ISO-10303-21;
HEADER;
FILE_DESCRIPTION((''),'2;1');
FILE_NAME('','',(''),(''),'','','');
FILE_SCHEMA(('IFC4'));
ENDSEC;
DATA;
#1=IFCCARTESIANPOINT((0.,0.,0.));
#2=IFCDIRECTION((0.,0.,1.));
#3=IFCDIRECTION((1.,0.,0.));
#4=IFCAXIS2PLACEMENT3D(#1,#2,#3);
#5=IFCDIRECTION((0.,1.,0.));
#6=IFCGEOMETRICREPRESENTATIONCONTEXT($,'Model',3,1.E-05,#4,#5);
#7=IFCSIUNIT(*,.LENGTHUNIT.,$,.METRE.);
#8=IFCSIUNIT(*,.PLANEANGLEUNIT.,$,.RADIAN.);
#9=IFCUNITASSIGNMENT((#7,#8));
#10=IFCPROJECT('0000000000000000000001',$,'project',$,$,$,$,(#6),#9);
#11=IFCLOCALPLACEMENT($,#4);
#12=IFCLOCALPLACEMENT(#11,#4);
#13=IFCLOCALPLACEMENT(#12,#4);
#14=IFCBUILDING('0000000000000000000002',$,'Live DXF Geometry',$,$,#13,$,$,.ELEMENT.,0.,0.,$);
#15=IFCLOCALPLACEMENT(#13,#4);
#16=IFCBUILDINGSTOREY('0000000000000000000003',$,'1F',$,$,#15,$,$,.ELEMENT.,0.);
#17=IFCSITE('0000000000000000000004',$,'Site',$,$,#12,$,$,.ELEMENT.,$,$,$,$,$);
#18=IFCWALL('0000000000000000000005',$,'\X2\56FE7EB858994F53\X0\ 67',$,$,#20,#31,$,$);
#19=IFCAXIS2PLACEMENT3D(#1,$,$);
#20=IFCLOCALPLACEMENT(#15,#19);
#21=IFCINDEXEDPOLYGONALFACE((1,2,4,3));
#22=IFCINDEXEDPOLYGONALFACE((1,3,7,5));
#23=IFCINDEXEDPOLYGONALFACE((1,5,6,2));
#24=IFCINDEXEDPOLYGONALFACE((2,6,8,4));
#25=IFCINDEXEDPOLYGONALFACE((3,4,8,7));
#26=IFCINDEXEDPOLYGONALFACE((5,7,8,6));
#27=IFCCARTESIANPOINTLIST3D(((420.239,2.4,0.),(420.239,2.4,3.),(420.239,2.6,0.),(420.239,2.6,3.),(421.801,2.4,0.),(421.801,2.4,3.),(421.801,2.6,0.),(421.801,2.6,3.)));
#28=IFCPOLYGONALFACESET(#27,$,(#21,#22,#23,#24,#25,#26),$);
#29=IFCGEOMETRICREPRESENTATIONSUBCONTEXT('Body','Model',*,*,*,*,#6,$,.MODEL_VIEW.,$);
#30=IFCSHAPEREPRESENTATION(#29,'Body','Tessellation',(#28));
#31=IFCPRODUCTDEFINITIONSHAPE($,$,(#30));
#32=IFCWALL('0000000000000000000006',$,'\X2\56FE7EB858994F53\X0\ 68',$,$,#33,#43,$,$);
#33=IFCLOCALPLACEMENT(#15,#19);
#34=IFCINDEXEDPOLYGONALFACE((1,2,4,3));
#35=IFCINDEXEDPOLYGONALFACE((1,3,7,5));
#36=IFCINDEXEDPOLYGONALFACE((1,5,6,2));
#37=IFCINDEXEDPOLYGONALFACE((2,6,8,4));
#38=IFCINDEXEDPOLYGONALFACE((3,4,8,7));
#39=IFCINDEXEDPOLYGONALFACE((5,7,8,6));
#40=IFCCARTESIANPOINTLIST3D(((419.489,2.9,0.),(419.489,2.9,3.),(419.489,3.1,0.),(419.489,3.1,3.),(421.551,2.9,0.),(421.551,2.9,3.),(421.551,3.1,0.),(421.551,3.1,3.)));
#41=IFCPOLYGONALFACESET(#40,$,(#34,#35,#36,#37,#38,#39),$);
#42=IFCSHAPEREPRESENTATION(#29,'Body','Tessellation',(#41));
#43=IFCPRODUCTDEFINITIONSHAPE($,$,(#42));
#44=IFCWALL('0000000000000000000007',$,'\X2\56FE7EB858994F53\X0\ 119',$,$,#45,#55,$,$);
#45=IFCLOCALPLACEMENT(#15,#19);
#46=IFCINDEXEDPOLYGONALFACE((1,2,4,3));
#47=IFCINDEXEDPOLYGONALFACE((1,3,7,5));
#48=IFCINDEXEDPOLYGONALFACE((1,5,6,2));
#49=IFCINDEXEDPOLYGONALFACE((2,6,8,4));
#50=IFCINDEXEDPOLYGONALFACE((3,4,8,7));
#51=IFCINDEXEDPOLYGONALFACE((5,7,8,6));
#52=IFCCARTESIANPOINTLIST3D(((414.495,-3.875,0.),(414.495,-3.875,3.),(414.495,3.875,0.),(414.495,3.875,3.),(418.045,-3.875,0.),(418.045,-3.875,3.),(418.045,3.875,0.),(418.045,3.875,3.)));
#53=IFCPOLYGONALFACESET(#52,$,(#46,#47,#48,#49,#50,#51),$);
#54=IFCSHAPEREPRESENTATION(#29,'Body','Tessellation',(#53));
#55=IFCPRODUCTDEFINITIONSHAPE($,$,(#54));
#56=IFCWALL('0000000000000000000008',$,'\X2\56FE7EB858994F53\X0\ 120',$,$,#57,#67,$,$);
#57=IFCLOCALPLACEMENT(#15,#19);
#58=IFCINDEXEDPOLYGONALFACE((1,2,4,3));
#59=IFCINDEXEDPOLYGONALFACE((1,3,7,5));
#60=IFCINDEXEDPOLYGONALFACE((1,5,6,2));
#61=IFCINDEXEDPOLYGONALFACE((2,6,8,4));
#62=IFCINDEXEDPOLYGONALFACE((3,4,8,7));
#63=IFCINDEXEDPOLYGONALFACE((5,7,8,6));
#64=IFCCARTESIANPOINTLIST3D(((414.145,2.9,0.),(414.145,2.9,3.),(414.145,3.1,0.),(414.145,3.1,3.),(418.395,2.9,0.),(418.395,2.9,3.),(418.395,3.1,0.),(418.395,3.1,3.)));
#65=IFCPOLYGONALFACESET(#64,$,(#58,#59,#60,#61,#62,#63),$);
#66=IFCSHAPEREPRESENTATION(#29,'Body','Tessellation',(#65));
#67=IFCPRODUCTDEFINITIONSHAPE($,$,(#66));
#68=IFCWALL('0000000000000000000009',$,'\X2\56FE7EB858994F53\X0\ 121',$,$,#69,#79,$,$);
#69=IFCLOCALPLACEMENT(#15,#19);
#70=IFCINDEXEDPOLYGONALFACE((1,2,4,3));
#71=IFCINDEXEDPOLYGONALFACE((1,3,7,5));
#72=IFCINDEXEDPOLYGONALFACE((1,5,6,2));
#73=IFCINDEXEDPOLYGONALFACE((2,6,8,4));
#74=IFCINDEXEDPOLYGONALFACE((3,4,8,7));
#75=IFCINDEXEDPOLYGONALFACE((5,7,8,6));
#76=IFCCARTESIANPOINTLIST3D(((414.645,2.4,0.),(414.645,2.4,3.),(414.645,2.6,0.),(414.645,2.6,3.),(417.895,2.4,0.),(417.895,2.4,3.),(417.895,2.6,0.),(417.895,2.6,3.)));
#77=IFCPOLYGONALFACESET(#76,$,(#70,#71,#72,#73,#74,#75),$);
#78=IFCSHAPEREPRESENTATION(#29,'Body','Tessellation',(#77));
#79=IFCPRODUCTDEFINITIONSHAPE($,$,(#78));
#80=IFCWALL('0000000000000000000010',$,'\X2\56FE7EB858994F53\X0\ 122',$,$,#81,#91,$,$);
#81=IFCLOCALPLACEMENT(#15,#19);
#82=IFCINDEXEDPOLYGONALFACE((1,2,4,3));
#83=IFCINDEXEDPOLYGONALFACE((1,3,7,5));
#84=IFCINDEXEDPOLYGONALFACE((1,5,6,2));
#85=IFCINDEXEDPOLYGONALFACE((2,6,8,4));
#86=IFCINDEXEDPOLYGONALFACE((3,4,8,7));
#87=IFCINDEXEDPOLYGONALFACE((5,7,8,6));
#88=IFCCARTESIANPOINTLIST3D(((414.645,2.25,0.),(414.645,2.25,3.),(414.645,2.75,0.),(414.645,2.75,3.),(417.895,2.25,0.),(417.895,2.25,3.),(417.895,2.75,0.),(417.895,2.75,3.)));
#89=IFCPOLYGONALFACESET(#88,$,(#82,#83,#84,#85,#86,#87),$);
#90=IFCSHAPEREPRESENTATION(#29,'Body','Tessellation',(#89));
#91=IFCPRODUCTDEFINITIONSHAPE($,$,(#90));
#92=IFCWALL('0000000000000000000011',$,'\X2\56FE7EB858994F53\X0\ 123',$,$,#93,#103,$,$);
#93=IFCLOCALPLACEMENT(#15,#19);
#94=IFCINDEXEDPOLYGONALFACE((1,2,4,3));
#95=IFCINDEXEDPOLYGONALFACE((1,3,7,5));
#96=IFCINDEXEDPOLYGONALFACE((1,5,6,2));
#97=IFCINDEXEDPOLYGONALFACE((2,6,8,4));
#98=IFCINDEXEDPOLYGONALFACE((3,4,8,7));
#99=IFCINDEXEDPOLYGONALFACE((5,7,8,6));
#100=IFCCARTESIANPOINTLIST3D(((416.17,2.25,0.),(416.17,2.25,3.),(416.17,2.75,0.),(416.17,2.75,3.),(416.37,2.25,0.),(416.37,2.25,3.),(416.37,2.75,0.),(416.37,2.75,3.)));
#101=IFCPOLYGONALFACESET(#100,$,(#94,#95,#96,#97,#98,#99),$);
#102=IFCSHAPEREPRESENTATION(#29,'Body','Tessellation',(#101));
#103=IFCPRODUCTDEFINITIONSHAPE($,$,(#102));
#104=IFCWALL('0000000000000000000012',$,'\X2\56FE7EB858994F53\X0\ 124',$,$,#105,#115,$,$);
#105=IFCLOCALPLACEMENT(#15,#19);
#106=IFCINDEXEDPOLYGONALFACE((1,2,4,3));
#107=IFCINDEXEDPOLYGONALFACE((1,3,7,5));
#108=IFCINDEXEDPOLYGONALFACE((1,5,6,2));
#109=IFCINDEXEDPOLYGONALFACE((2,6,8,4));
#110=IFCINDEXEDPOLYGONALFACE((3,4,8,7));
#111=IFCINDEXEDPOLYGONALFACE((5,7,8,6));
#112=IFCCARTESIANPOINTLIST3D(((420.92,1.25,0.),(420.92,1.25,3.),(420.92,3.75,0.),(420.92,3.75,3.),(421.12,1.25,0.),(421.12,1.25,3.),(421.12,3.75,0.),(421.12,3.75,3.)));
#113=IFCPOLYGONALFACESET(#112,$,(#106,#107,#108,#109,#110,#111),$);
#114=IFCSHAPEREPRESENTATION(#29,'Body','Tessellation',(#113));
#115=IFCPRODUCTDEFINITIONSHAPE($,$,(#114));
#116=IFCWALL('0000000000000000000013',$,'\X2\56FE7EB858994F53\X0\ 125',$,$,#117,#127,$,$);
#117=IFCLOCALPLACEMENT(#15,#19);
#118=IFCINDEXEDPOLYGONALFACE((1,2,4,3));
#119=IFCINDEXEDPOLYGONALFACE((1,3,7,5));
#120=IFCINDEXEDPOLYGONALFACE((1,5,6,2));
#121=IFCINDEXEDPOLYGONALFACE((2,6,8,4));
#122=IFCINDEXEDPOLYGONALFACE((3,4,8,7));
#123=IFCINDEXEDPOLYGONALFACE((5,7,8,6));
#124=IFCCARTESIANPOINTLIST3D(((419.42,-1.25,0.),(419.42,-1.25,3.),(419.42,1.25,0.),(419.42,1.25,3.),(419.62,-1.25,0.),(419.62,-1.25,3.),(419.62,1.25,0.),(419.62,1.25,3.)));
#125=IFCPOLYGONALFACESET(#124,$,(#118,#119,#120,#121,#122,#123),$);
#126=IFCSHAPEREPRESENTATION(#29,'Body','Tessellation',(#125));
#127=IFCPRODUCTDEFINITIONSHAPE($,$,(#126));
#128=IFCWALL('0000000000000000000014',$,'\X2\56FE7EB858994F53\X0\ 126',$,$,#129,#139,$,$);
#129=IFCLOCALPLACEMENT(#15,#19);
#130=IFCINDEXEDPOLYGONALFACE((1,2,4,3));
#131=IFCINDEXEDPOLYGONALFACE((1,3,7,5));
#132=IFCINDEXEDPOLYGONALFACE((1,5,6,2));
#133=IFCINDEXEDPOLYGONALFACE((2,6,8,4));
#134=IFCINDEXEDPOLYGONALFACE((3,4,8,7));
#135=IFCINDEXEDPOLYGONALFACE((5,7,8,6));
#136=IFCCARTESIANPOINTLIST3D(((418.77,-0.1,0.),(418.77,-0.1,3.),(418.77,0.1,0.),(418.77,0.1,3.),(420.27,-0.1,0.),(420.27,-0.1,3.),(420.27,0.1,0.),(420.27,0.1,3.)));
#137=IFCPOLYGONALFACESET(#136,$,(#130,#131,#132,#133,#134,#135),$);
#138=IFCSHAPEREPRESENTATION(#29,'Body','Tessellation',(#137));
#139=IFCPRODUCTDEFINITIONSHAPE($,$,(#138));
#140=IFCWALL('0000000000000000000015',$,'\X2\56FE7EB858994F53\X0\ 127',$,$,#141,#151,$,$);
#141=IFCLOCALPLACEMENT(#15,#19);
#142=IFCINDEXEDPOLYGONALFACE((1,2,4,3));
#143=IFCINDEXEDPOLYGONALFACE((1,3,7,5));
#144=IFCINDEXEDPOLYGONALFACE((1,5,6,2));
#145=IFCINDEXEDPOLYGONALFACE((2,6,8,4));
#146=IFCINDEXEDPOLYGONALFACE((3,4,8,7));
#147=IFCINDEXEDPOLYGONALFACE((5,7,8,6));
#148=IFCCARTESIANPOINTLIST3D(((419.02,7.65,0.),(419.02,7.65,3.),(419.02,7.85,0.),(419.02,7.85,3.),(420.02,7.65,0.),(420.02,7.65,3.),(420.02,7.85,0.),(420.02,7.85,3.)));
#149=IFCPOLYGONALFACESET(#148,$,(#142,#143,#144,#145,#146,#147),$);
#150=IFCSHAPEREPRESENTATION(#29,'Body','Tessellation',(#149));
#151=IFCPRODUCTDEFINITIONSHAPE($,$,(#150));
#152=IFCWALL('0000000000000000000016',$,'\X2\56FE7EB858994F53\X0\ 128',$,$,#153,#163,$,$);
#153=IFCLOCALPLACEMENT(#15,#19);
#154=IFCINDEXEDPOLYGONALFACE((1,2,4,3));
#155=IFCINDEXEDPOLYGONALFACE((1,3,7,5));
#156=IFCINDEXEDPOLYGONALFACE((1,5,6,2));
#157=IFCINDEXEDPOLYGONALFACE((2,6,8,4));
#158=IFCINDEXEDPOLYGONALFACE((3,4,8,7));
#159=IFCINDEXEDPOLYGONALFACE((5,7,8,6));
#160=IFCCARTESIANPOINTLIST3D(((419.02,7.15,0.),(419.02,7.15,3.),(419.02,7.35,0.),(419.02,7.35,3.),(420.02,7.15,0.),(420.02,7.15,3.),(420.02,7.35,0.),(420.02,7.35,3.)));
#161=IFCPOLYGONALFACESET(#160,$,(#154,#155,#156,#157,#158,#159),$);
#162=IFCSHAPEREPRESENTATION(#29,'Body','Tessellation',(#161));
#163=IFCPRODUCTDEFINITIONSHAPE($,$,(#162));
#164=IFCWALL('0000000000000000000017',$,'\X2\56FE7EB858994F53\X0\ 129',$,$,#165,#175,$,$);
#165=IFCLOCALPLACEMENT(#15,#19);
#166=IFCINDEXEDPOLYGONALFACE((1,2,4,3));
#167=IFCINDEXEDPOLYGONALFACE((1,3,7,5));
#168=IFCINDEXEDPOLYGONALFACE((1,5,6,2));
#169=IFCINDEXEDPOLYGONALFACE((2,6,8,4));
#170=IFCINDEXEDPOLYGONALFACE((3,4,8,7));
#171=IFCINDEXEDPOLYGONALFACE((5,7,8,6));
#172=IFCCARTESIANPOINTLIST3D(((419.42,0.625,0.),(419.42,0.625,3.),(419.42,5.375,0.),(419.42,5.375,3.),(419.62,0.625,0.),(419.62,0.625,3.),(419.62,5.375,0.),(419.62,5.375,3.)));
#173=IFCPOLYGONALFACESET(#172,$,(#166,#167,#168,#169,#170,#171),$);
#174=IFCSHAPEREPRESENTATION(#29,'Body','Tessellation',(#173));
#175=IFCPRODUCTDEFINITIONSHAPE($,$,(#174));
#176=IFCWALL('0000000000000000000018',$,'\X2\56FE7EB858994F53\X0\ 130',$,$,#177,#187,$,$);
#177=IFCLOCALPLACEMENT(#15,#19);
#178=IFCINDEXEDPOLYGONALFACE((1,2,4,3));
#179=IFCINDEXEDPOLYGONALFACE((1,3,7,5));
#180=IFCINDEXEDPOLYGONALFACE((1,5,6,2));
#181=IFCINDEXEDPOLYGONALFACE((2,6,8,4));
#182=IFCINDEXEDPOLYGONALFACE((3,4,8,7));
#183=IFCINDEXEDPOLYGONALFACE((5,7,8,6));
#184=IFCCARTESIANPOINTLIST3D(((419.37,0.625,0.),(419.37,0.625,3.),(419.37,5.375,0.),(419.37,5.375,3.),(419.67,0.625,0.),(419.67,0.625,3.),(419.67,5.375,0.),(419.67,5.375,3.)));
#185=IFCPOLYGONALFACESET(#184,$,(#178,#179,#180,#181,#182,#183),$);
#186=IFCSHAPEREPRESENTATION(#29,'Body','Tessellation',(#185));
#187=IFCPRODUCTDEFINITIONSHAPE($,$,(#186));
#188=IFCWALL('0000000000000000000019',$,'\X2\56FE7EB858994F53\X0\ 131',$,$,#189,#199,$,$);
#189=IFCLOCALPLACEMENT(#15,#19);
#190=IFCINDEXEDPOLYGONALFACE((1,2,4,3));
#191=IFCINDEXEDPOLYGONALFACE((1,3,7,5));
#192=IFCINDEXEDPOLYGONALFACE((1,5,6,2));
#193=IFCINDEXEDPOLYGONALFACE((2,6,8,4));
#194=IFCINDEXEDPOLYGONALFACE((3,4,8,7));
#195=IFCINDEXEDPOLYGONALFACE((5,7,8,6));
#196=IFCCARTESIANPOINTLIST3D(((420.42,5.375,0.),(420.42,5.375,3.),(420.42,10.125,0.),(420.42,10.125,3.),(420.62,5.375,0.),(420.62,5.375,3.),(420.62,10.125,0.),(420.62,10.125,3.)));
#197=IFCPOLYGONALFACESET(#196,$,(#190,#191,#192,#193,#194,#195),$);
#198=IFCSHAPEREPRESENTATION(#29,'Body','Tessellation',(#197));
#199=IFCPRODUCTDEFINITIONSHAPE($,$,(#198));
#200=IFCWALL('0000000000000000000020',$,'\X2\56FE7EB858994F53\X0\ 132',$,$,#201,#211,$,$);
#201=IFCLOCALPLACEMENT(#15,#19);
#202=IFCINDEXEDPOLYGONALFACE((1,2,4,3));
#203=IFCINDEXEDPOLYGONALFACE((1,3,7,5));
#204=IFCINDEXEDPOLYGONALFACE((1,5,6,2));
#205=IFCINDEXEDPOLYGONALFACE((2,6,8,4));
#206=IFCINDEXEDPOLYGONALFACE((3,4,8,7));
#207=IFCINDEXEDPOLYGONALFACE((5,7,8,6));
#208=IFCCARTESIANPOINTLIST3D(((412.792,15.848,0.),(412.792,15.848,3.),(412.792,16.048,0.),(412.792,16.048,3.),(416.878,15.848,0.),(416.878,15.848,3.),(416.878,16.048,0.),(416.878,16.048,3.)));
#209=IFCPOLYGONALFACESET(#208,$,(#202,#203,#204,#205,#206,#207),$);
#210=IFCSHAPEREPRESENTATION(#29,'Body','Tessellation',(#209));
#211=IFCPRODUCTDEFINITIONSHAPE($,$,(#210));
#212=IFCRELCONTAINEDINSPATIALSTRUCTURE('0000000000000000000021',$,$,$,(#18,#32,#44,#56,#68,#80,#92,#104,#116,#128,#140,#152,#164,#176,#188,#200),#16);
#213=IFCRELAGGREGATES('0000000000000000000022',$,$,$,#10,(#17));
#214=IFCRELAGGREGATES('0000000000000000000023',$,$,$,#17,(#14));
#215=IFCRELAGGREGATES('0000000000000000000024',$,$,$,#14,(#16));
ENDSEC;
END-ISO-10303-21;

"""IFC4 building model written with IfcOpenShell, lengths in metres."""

from ifc_helpers import new_model, si_unit, direction, frame, frame_2d, origin_with_axes, place, context, subcontext, project, spatial, rectangle, extrude, element, save


model = new_model("IFC4")

# Units and contexts
model_context = context("Model", 3, precision=1e-05, world=origin_with_axes(), true_north=direction((0.0, 1.0, 0.0)))
body_context = subcontext(model_context, "Body", "Model", "MODEL_VIEW")
ifc_project = project(units=[si_unit("LENGTHUNIT", "METRE"), si_unit("PLANEANGLEUNIT", "RADIAN")], contexts=[model_context])

# Site, building, storey
placement = place(None, origin_with_axes())
site_placement = place(placement, origin_with_axes())
site = spatial("IfcSite", under=ifc_project, at=site_placement, Name="Site", CompositionType="ELEMENT")
building_placement = place(site_placement, origin_with_axes())
building = spatial("IfcBuilding", under=site, at=building_placement, Name="Live DXF Geometry", CompositionType="ELEMENT", ElevationOfRefHeight=0.0, ElevationOfTerrain=0.0)
storey_placement = place(building_placement, origin_with_axes())
storey = spatial("IfcBuildingStorey", under=building, at=storey_placement, Name="1F", CompositionType="ELEMENT", Elevation=0.0)

# Walls
wall_1_placement = place(storey_placement, frame((421.02, 2.5, 0.0), z_axis=(0.0, 0.0, 1.0), x_axis=(1.0, 0.0, 0.0)))
element("IfcWall", 1, at=wall_1_placement, inside=storey, Name="图纸墙体 67", context=body_context, shape_type="SweptSolid", body=[
    extrude(rectangle(XDim=1.562, YDim=0.2, at=frame_2d((0.0, 0.0), x_axis=(1.0, 0.0, 0.0))), frame((0.0, 0.0, 0.0), z_axis=(0.0, 0.0, 1.0)), (0.0, 0.0, 1.0), 3.0),
])
wall_2_placement = place(storey_placement, frame((420.52, 3.0, 0.0), z_axis=(0.0, 0.0, 1.0), x_axis=(1.0, 0.0, 0.0)))
element("IfcWall", 2, at=wall_2_placement, inside=storey, Name="图纸墙体 68", context=body_context, shape_type="SweptSolid", body=[
    extrude(rectangle(XDim=2.062, YDim=0.2, at=frame_2d((0.0, 0.0), x_axis=(1.0, 0.0, 0.0))), frame((0.0, 0.0, 0.0), z_axis=(0.0, 0.0, 1.0)), (0.0, 0.0, 1.0), 3.0),
])
wall_3_placement = place(storey_placement, frame((416.27, 0.0, 0.0), z_axis=(0.0, 0.0, 1.0), x_axis=(1.0, 0.0, 0.0)))
element("IfcWall", 3, at=wall_3_placement, inside=storey, Name="图纸墙体 119", context=body_context, shape_type="SweptSolid", body=[
    extrude(rectangle(XDim=3.55, YDim=7.75, at=frame_2d((0.0, 0.0), x_axis=(1.0, 0.0, 0.0))), frame((0.0, 0.0, 0.0), z_axis=(0.0, 0.0, 1.0)), (0.0, 0.0, 1.0), 3.0),
])
wall_4_placement = place(storey_placement, frame((416.27, 3.0, 0.0), z_axis=(0.0, 0.0, 1.0), x_axis=(1.0, 0.0, 0.0)))
element("IfcWall", 4, at=wall_4_placement, inside=storey, Name="图纸墙体 120", context=body_context, shape_type="SweptSolid", body=[
    extrude(rectangle(XDim=4.25, YDim=0.2, at=frame_2d((0.0, 0.0), x_axis=(1.0, 0.0, 0.0))), frame((0.0, 0.0, 0.0), z_axis=(0.0, 0.0, 1.0)), (0.0, 0.0, 1.0), 3.0),
])
wall_5_placement = place(storey_placement, frame((416.27, 2.5, 0.0), z_axis=(0.0, 0.0, 1.0), x_axis=(1.0, 0.0, 0.0)))
element("IfcWall", 5, at=wall_5_placement, inside=storey, Name="图纸墙体 121", context=body_context, shape_type="SweptSolid", body=[
    extrude(rectangle(XDim=3.25, YDim=0.2, at=frame_2d((0.0, 0.0), x_axis=(1.0, 0.0, 0.0))), frame((0.0, 0.0, 0.0), z_axis=(0.0, 0.0, 1.0)), (0.0, 0.0, 1.0), 3.0),
])
wall_6_placement = place(storey_placement, frame((416.27, 2.5, 0.0), z_axis=(0.0, 0.0, 1.0), x_axis=(1.0, 0.0, 0.0)))
element("IfcWall", 6, at=wall_6_placement, inside=storey, Name="图纸墙体 122", context=body_context, shape_type="SweptSolid", body=[
    extrude(rectangle(XDim=3.25, YDim=0.5, at=frame_2d((0.0, 0.0), x_axis=(1.0, 0.0, 0.0))), frame((0.0, 0.0, 0.0), z_axis=(0.0, 0.0, 1.0)), (0.0, 0.0, 1.0), 3.0),
])
wall_7_placement = place(storey_placement, frame((416.27, 2.5, 0.0), z_axis=(0.0, 0.0, 1.0), x_axis=(0.0, 1.0, 0.0)))
element("IfcWall", 7, at=wall_7_placement, inside=storey, Name="图纸墙体 123", context=body_context, shape_type="SweptSolid", body=[
    extrude(rectangle(XDim=0.5, YDim=0.2, at=frame_2d((0.0, 0.0), x_axis=(1.0, 0.0, 0.0))), frame((0.0, 0.0, 0.0), z_axis=(0.0, 0.0, 1.0)), (0.0, 0.0, 1.0), 3.0),
])
for number, where, z_axis, x_axis, name in (
    (8, (421.02, 2.5, 0.0), (0.0, 0.0, 1.0), (0.0, -1.0, 0.0), "图纸墙体 124"),
    (9, (419.52, 0.0, 0.0), (0.0, 0.0, 1.0), (0.0, 1.0, 0.0), "图纸墙体 125"),
):
    element("IfcWall", number, at=place(storey_placement, frame(where, z_axis=z_axis, x_axis=x_axis)), inside=storey, Name=name, context=body_context, shape_type="SweptSolid", body=[
        extrude(rectangle(XDim=2.5, YDim=0.2, at=frame_2d((0.0, 0.0), x_axis=(1.0, 0.0, 0.0))), frame((0.0, 0.0, 0.0), z_axis=(0.0, 0.0, 1.0)), (0.0, 0.0, 1.0), 3.0),
    ])
wall_8_placement = place(storey_placement, frame((419.52, 0.0, 0.0), z_axis=(0.0, 0.0, 1.0), x_axis=(1.0, 0.0, 0.0)))
element("IfcWall", 10, at=wall_8_placement, inside=storey, Name="图纸墙体 126", context=body_context, shape_type="SweptSolid", body=[
    extrude(rectangle(XDim=1.5, YDim=0.2, at=frame_2d((0.0, 0.0), x_axis=(1.0, 0.0, 0.0))), frame((0.0, 0.0, 0.0), z_axis=(0.0, 0.0, 1.0)), (0.0, 0.0, 1.0), 3.0),
])
for number, where, z_axis, x_axis, name in (
    (11, (419.52, 7.75, 0.0), (0.0, 0.0, 1.0), (1.0, 0.0, 0.0), "图纸墙体 127"),
    (12, (419.52, 7.25, 0.0), (0.0, 0.0, 1.0), (1.0, 0.0, 0.0), "图纸墙体 128"),
):
    element("IfcWall", number, at=place(storey_placement, frame(where, z_axis=z_axis, x_axis=x_axis)), inside=storey, Name=name, context=body_context, shape_type="SweptSolid", body=[
        extrude(rectangle(XDim=1.0, YDim=0.2, at=frame_2d((0.0, 0.0), x_axis=(1.0, 0.0, 0.0))), frame((0.0, 0.0, 0.0), z_axis=(0.0, 0.0, 1.0)), (0.0, 0.0, 1.0), 3.0),
    ])
wall_9_placement = place(storey_placement, frame((419.52, 3.0, 0.0), z_axis=(0.0, 0.0, 1.0), x_axis=(0.0, 1.0, 0.0)))
element("IfcWall", 13, at=wall_9_placement, inside=storey, Name="图纸墙体 129", context=body_context, shape_type="SweptSolid", body=[
    extrude(rectangle(XDim=4.75, YDim=0.2, at=frame_2d((0.0, 0.0), x_axis=(1.0, 0.0, 0.0))), frame((0.0, 0.0, 0.0), z_axis=(0.0, 0.0, 1.0)), (0.0, 0.0, 1.0), 3.0),
])
wall_10_placement = place(storey_placement, frame((419.52, 3.0, 0.0), z_axis=(0.0, 0.0, 1.0), x_axis=(1.0, 0.0, 0.0)))
element("IfcWall", 14, at=wall_10_placement, inside=storey, Name="图纸墙体 130", context=body_context, shape_type="SweptSolid", body=[
    extrude(rectangle(XDim=0.3, YDim=4.75, at=frame_2d((0.0, 0.0), x_axis=(1.0, 0.0, 0.0))), frame((0.0, 0.0, 0.0), z_axis=(0.0, 0.0, 1.0)), (0.0, 0.0, 1.0), 3.0),
])
wall_11_placement = place(storey_placement, frame((420.52, 7.75, 0.0), z_axis=(0.0, 0.0, 1.0), x_axis=(0.0, -1.0, 0.0)))
element("IfcWall", 15, at=wall_11_placement, inside=storey, Name="图纸墙体 131", context=body_context, shape_type="SweptSolid", body=[
    extrude(rectangle(XDim=4.75, YDim=0.2, at=frame_2d((0.0, 0.0), x_axis=(1.0, 0.0, 0.0))), frame((0.0, 0.0, 0.0), z_axis=(0.0, 0.0, 1.0)), (0.0, 0.0, 1.0), 3.0),
])
for number, where, z_axis, x_axis, name in (
    (16, (414.835, 15.948, 0.0), (0.0, 0.0, 1.0), (1.0, 0.0, 0.0), "图纸墙体 132"),
):
    element("IfcWall", number, at=place(storey_placement, frame(where, z_axis=z_axis, x_axis=x_axis)), inside=storey, Name=name, context=body_context, shape_type="SweptSolid", body=[
        extrude(rectangle(XDim=4.086, YDim=0.2, at=frame_2d((0.0, 0.0), x_axis=(1.0, 0.0, 0.0))), frame((0.0, 0.0, 0.0), z_axis=(0.0, 0.0, 1.0)), (0.0, 0.0, 1.0), 3.0),
    ])

save(model, "model.ifc")
